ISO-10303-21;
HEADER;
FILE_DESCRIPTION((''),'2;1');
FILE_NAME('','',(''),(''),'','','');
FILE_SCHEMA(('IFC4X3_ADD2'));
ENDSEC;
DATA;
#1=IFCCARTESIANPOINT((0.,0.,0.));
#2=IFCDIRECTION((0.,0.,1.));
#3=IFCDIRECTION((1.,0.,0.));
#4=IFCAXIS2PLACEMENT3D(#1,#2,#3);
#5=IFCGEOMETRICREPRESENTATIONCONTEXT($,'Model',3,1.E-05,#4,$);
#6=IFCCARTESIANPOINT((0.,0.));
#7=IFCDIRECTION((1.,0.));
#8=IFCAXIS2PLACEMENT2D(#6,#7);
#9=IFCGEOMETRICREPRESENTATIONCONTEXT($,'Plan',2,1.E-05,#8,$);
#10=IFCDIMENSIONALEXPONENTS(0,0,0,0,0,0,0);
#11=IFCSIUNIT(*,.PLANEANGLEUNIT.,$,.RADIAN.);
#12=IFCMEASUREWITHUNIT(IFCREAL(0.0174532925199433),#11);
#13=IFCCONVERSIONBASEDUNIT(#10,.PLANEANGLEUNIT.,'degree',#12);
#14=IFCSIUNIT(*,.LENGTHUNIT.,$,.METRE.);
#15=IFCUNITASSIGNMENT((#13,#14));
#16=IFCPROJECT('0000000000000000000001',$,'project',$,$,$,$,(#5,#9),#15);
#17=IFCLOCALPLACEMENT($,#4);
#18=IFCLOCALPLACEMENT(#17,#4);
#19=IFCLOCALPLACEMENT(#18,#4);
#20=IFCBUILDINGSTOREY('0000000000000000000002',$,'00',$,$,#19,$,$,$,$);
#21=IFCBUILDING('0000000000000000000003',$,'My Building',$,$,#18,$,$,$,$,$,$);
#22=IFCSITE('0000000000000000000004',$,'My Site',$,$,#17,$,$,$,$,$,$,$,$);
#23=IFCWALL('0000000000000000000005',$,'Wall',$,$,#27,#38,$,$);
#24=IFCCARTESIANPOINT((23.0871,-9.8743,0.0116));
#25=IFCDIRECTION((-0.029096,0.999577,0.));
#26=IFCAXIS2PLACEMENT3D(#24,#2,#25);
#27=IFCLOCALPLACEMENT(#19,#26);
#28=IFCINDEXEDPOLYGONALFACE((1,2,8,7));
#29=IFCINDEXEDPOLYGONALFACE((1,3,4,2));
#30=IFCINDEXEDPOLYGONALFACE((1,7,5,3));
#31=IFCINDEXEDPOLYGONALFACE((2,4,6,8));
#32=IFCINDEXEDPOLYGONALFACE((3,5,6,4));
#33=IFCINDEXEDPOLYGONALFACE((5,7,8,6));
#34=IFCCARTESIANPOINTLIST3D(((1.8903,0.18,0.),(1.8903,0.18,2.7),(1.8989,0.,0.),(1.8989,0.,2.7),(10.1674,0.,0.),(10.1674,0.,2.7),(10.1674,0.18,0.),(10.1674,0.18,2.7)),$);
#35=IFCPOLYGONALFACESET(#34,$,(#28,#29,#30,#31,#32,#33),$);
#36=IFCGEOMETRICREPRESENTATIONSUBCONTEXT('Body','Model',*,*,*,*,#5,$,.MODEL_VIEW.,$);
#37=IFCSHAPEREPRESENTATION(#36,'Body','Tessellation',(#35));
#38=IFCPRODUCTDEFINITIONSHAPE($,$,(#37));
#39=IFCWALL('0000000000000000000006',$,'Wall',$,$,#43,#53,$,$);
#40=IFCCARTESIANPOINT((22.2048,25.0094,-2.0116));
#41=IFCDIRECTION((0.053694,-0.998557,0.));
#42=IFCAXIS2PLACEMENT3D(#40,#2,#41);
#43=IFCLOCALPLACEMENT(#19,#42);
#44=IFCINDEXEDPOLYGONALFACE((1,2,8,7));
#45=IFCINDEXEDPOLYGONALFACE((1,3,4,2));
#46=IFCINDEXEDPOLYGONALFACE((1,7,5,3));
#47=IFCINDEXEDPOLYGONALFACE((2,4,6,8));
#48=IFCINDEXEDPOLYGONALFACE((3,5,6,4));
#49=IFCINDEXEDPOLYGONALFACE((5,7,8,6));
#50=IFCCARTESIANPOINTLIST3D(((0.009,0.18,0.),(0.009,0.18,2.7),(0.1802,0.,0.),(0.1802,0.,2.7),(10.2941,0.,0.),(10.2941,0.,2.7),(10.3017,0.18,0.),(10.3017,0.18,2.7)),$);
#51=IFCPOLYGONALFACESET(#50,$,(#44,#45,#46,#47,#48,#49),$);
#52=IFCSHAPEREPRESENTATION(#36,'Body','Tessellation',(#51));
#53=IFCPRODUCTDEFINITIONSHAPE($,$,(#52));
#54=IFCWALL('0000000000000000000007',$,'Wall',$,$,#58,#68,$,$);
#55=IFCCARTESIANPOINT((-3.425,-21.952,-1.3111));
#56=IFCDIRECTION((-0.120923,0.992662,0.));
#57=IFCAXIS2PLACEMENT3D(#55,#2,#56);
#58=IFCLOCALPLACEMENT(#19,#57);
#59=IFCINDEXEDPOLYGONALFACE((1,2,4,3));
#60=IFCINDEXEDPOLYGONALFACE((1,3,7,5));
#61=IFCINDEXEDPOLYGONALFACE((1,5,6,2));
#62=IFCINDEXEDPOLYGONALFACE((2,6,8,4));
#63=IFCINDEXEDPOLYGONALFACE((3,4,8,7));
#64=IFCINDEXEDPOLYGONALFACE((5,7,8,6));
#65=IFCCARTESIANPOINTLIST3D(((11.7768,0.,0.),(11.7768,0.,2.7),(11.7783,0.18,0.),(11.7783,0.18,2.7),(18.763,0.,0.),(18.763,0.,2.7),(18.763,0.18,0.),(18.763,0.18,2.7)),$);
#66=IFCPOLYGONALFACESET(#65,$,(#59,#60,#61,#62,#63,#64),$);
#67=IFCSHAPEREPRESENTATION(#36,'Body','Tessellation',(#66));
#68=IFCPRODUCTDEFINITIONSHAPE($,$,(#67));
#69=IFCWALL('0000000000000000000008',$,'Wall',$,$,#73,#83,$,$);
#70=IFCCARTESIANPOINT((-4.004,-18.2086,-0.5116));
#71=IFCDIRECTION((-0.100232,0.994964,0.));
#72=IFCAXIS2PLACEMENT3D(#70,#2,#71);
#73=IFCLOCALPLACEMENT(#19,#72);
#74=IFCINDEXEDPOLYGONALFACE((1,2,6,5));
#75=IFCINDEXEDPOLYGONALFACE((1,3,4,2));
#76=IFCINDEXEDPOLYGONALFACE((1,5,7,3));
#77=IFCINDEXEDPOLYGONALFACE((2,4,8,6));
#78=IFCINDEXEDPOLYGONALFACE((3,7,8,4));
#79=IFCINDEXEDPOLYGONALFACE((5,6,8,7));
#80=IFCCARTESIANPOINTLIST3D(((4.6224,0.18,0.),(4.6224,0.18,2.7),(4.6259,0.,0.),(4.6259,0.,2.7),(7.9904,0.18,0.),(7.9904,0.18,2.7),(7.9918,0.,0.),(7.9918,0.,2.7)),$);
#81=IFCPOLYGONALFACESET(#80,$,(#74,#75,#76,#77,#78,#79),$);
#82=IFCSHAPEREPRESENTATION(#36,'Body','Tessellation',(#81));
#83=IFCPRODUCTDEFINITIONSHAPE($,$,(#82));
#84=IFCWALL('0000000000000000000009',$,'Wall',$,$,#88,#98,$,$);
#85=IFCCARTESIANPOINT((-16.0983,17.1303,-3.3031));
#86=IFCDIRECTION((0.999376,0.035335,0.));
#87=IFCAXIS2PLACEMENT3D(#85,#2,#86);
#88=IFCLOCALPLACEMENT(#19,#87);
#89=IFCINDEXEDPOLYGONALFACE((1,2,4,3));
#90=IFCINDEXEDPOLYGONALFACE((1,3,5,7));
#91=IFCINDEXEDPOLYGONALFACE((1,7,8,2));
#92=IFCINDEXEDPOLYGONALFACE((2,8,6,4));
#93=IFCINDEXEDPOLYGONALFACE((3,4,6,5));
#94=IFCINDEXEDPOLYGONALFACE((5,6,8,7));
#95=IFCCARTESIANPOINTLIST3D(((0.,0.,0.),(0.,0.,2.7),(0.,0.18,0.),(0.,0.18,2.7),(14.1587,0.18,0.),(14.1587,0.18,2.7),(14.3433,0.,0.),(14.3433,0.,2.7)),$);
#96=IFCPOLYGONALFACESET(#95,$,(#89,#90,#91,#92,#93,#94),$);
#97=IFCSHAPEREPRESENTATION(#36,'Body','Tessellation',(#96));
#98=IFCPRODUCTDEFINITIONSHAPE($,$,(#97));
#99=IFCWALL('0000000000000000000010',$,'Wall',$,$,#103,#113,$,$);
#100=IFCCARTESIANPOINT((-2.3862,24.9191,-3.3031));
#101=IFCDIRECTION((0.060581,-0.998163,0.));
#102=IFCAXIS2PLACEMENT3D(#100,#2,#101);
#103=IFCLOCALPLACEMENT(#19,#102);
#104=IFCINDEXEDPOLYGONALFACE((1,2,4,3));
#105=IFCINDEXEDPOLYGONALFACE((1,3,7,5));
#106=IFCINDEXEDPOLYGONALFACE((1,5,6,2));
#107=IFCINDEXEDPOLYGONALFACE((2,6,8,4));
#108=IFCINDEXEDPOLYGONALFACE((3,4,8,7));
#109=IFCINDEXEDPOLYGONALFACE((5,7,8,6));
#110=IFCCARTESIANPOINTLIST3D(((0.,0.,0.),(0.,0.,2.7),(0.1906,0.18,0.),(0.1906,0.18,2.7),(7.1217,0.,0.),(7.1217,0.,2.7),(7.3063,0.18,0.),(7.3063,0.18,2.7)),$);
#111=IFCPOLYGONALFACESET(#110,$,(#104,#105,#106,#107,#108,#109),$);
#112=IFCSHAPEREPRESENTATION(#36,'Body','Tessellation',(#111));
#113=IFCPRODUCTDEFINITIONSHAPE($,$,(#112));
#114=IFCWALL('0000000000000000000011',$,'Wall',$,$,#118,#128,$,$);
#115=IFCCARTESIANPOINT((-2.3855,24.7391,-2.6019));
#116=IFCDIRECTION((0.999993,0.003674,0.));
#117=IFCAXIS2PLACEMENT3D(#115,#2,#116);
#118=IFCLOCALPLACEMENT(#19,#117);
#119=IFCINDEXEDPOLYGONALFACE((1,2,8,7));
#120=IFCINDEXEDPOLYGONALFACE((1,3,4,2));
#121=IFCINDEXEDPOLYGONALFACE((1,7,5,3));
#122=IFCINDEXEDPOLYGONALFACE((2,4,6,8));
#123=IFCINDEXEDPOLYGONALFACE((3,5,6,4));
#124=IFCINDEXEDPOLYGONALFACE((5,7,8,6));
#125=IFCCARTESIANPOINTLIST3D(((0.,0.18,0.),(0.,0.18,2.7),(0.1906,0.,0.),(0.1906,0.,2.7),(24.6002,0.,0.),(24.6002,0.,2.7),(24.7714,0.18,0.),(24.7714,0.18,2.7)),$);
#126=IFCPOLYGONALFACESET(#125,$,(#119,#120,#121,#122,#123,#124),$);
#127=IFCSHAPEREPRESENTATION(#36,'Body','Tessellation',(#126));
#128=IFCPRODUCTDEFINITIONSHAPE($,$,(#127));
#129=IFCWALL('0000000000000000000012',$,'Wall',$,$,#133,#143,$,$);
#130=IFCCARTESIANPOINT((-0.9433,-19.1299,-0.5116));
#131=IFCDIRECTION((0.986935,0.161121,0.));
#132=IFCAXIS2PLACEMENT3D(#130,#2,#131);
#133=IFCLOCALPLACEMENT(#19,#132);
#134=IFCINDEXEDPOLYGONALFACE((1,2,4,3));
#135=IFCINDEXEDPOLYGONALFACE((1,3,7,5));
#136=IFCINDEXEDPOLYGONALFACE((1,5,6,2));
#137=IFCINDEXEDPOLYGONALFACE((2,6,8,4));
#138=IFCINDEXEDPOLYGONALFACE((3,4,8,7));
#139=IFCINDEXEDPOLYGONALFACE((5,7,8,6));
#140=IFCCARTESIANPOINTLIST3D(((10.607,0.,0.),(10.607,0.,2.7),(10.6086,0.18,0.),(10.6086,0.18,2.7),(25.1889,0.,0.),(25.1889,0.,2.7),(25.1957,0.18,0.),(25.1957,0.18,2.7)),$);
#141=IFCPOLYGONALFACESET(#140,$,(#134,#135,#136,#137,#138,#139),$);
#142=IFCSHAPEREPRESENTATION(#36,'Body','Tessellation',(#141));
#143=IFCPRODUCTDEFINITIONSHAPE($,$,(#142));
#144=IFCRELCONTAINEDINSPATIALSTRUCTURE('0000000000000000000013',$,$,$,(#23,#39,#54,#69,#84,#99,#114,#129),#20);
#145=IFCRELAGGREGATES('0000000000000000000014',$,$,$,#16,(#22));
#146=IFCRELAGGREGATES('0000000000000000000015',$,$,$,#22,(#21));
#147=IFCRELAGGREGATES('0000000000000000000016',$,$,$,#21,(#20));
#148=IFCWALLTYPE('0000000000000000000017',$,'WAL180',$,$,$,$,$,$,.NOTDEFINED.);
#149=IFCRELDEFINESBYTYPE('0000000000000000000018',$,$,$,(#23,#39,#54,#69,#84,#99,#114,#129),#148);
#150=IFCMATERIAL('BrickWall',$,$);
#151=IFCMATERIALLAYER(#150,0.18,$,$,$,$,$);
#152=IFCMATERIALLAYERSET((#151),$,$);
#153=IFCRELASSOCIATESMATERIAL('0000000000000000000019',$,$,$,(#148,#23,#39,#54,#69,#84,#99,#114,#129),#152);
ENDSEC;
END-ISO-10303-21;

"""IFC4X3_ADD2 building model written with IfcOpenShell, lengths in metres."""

from ifc_helpers import new_model, entity, si_unit, converted_unit, frame, origin_with_axes, origin_2d_with_axis, place, context, subcontext, project, spatial, indexed_curve, outline, extrude, clip, halfspace, material, layer, layer_set, layer_usage, type_object, element, save


model = new_model("IFC4X3_ADD2")

# Units and contexts
model_context = context("Model", 3, precision=1e-05, world=origin_with_axes())
plan_context = context("Plan", 2, precision=1e-05, world=origin_2d_with_axis())
body_context = subcontext(model_context, "Body", "Model", "MODEL_VIEW")
ifc_project = project(units=[converted_unit("PLANEANGLEUNIT", "degree", entity("IfcReal", 0.0174532925199433), si_unit("PLANEANGLEUNIT", "RADIAN"), dimensions=[0, 0, 0, 0, 0, 0, 0]), si_unit("LENGTHUNIT", "METRE")], contexts=[model_context, plan_context])

# Site, building, storey
site_placement = place(None, origin_with_axes())
site = spatial("IfcSite", under=ifc_project, at=site_placement, Name="My Site")
building_placement = place(site_placement, origin_with_axes())
building = spatial("IfcBuilding", under=site, at=building_placement, Name="My Building")
storey_placement = place(building_placement, origin_with_axes())
storey = spatial("IfcBuildingStorey", under=building, at=storey_placement, Name="00")

# Walls
ifc_material = material(Name="BrickWall")
ifc_layer = layer(ifc_material, 0.18)
ifc_layer_set = layer_set([ifc_layer])
wall_type = type_object("IfcWallType", Name="WAL180", PredefinedType="NOTDEFINED", material=ifc_layer_set)
ifc_layer_usage_1 = layer_usage(ifc_layer_set, "AXIS2", "POSITIVE", 0.0)
wall_1_placement = place(storey_placement, frame((23.0871, -9.8743, 0.0116), z_axis=(0.0, 0.0, 1.0), x_axis=(-0.029096, 0.999577, 0.0)))
element("IfcWall", 1, at=wall_1_placement, inside=storey, type_object=wall_type, material=ifc_layer_usage_1, Name="Wall", context=body_context, shape_type="Clipping", body=[
    clip(extrude(outline(indexed_curve([(0.0, 0.0), (0.0, 0.18), (10.1674, 0.18), (10.1674, 0.0), (0.0, 0.0)], self_intersect=False)), origin_with_axes(), (0.0, 0.0, 1.0), 2.7), halfspace(frame((1.8989, 0.0, -0.0116), z_axis=(-0.99887, -0.047523, 0.0), x_axis=(-0.047523, 0.99887, 0.0)), False)),
])
ifc_layer_usage_2 = layer_usage(ifc_layer_set, "AXIS2", "POSITIVE", 0.0)
wall_2_placement = place(storey_placement, frame((22.2048, 25.0094, -2.0116), z_axis=(0.0, 0.0, 1.0), x_axis=(0.053694, -0.998557, 0.0)))
element("IfcWall", 2, at=wall_2_placement, inside=storey, type_object=wall_type, material=ifc_layer_usage_2, Name="Wall", context=body_context, shape_type="Clipping", body=[
    clip(clip(extrude(outline(indexed_curve([(0.0, 0.0), (0.0, 0.18), (12.4301, 0.18), (12.4301, 0.0), (0.0, 0.0)], self_intersect=False)), origin_with_axes(), (0.0, 0.0, 1.0), 2.7), halfspace(frame((0.1802, 0.0, 2.0116), z_axis=(-0.724577, -0.689194, 0.0), x_axis=(-0.689194, 0.724577, 0.0)), False)), halfspace(frame((10.2941, 0.0, 2.0116), z_axis=(0.999108, -0.042241, 0.0), x_axis=(-0.042241, -0.999107, 0.0)), False)),
])
ifc_layer_usage_3 = layer_usage(ifc_layer_set, "AXIS2", "POSITIVE", 0.0)
wall_3_placement = place(storey_placement, frame((-3.425, -21.952, -1.3111), z_axis=(0.0, 0.0, 1.0), x_axis=(-0.120923, 0.992662, 0.0)))
element("IfcWall", 3, at=wall_3_placement, inside=storey, type_object=wall_type, material=ifc_layer_usage_3, Name="Wall", context=body_context, shape_type="Clipping", body=[
    clip(extrude(outline(indexed_curve([(0.0, 0.0), (0.0, 0.18), (18.763, 0.18), (18.763, 0.0), (0.0, 0.0)], self_intersect=False)), origin_with_axes(), (0.0, 0.0, 1.0), 2.7), halfspace(frame((11.7768, 0.0, 0.5116), z_axis=(-0.999969, 0.007908, 0.0), x_axis=(0.007908, 0.999969, 0.0)), False)),
])
ifc_layer_usage_4 = layer_usage(ifc_layer_set, "AXIS2", "POSITIVE", 0.0)
wall_4_placement = place(storey_placement, frame((-4.004, -18.2086, -0.5116), z_axis=(0.0, 0.0, 1.0), x_axis=(-0.100232, 0.994964, 0.0)))
element("IfcWall", 4, at=wall_4_placement, inside=storey, type_object=wall_type, material=ifc_layer_usage_4, Name="Wall", context=body_context, shape_type="Clipping", body=[
    clip(clip(extrude(outline(indexed_curve([(0.0, 0.0), (0.0, 0.18), (19.7687, 0.18), (19.7687, 0.0), (0.0, 0.0)], self_intersect=False)), origin_with_axes(), (0.0, 0.0, 1.0), 2.7), halfspace(frame((4.6259, 0.0, 0.5116), z_axis=(-0.99981, -0.019519, 0.0), x_axis=(-0.019519, 0.999809, 0.0)), False)), halfspace(frame((7.9918, 0.0, 0.5116), z_axis=(0.999972, 0.007553, 0.0), x_axis=(0.007553, -0.999971, 0.0)), False)),
])
ifc_layer_usage_5 = layer_usage(ifc_layer_set, "AXIS2", "POSITIVE", 0.0)
wall_5_placement = place(storey_placement, frame((-16.0983, 17.1303, -3.3031), z_axis=(0.0, 0.0, 1.0), x_axis=(0.999376, 0.035335, 0.0)))
element("IfcWall", 5, at=wall_5_placement, inside=storey, type_object=wall_type, material=ifc_layer_usage_5, Name="Wall", context=body_context, shape_type="Clipping", body=[
    clip(extrude(outline(indexed_curve([(0.0, 0.0), (0.0, 0.18), (14.3433, 0.18), (14.3433, 0.0), (0.0, 0.0)], self_intersect=False)), origin_with_axes(), (0.0, 0.0, 1.0), 2.7), halfspace(frame((14.3433, 0.0, 2.6019), z_axis=(0.698115, 0.715986, 0.0), x_axis=(0.715986, -0.698114, 0.0)), False)),
])
ifc_layer_usage_6 = layer_usage(ifc_layer_set, "AXIS2", "POSITIVE", 0.0)
wall_6_placement = place(storey_placement, frame((-2.3862, 24.9191, -3.3031), z_axis=(0.0, 0.0, 1.0), x_axis=(0.060581, -0.998163, 0.0)))
element("IfcWall", 6, at=wall_6_placement, inside=storey, type_object=wall_type, material=ifc_layer_usage_6, Name="Wall", context=body_context, shape_type="Clipping", body=[
    clip(clip(extrude(outline(indexed_curve([(0.0, 0.0), (0.0, 0.18), (7.3063, 0.18), (7.3063, 0.0), (0.0, 0.0)], self_intersect=False)), origin_with_axes(), (0.0, 0.0, 1.0), 2.7), halfspace(frame((0.0, 0.0, 2.6019), z_axis=(-0.686695, 0.726946, 0.0), x_axis=(0.726946, 0.686695, 0.0)), False)), halfspace(frame((7.1217, 0.0, 2.6019), z_axis=(0.698115, -0.715986, 0.0), x_axis=(-0.715986, -0.698115, 0.0)), False)),
])
ifc_layer_usage_7 = layer_usage(ifc_layer_set, "AXIS2", "POSITIVE", 0.0)
wall_7_placement = place(storey_placement, frame((-2.3855, 24.7391, -2.6019), z_axis=(0.0, 0.0, 1.0), x_axis=(0.999993, 0.003674, 0.0)))
element("IfcWall", 7, at=wall_7_placement, inside=storey, type_object=wall_type, material=ifc_layer_usage_7, Name="Wall", context=body_context, shape_type="Clipping", body=[
    clip(clip(extrude(outline(indexed_curve([(0.0, 0.0), (0.0, 0.18), (24.7804, 0.18), (24.7804, 0.0), (0.0, 0.0)], self_intersect=False)), origin_with_axes(), (0.0, 0.0, 1.0), 2.7), halfspace(frame((0.1906, 0.0, 2.6019), z_axis=(-0.686687, -0.726954, 0.0), x_axis=(-0.726953, 0.686687, 0.0)), False)), halfspace(frame((24.6002, 0.0, 2.6019), z_axis=(0.724574, -0.689198, 0.0), x_axis=(-0.689198, -0.724573, 0.0)), False)),
])
ifc_layer_usage_8 = layer_usage(ifc_layer_set, "AXIS2", "POSITIVE", 0.0)
wall_8_placement = place(storey_placement, frame((-0.9433, -19.1299, -0.5116), z_axis=(0.0, 0.0, 1.0), x_axis=(0.986935, 0.161121, 0.0)))
element("IfcWall", 8, at=wall_8_placement, inside=storey, type_object=wall_type, material=ifc_layer_usage_8, Name="Wall", context=body_context, shape_type="Clipping", body=[
    clip(clip(extrude(outline(indexed_curve([(0.0, 0.0), (0.0, 0.18), (25.1957, 0.18), (25.1957, 0.0), (0.0, 0.0)], self_intersect=False)), origin_with_axes(), (0.0, 0.0, 1.0), 2.7), halfspace(frame((10.607, 0.0, 0.5116), z_axis=(-0.999961, 0.008825, 0.0), x_axis=(0.008825, 0.999961, 0.0)), False)), halfspace(frame((25.1889, 0.0, 0.5116), z_axis=(0.486001, -0.018379, 0.0), x_axis=(-0.03779, -0.999286, 0.0)), False)),
])

save(model, "model.ifc")
